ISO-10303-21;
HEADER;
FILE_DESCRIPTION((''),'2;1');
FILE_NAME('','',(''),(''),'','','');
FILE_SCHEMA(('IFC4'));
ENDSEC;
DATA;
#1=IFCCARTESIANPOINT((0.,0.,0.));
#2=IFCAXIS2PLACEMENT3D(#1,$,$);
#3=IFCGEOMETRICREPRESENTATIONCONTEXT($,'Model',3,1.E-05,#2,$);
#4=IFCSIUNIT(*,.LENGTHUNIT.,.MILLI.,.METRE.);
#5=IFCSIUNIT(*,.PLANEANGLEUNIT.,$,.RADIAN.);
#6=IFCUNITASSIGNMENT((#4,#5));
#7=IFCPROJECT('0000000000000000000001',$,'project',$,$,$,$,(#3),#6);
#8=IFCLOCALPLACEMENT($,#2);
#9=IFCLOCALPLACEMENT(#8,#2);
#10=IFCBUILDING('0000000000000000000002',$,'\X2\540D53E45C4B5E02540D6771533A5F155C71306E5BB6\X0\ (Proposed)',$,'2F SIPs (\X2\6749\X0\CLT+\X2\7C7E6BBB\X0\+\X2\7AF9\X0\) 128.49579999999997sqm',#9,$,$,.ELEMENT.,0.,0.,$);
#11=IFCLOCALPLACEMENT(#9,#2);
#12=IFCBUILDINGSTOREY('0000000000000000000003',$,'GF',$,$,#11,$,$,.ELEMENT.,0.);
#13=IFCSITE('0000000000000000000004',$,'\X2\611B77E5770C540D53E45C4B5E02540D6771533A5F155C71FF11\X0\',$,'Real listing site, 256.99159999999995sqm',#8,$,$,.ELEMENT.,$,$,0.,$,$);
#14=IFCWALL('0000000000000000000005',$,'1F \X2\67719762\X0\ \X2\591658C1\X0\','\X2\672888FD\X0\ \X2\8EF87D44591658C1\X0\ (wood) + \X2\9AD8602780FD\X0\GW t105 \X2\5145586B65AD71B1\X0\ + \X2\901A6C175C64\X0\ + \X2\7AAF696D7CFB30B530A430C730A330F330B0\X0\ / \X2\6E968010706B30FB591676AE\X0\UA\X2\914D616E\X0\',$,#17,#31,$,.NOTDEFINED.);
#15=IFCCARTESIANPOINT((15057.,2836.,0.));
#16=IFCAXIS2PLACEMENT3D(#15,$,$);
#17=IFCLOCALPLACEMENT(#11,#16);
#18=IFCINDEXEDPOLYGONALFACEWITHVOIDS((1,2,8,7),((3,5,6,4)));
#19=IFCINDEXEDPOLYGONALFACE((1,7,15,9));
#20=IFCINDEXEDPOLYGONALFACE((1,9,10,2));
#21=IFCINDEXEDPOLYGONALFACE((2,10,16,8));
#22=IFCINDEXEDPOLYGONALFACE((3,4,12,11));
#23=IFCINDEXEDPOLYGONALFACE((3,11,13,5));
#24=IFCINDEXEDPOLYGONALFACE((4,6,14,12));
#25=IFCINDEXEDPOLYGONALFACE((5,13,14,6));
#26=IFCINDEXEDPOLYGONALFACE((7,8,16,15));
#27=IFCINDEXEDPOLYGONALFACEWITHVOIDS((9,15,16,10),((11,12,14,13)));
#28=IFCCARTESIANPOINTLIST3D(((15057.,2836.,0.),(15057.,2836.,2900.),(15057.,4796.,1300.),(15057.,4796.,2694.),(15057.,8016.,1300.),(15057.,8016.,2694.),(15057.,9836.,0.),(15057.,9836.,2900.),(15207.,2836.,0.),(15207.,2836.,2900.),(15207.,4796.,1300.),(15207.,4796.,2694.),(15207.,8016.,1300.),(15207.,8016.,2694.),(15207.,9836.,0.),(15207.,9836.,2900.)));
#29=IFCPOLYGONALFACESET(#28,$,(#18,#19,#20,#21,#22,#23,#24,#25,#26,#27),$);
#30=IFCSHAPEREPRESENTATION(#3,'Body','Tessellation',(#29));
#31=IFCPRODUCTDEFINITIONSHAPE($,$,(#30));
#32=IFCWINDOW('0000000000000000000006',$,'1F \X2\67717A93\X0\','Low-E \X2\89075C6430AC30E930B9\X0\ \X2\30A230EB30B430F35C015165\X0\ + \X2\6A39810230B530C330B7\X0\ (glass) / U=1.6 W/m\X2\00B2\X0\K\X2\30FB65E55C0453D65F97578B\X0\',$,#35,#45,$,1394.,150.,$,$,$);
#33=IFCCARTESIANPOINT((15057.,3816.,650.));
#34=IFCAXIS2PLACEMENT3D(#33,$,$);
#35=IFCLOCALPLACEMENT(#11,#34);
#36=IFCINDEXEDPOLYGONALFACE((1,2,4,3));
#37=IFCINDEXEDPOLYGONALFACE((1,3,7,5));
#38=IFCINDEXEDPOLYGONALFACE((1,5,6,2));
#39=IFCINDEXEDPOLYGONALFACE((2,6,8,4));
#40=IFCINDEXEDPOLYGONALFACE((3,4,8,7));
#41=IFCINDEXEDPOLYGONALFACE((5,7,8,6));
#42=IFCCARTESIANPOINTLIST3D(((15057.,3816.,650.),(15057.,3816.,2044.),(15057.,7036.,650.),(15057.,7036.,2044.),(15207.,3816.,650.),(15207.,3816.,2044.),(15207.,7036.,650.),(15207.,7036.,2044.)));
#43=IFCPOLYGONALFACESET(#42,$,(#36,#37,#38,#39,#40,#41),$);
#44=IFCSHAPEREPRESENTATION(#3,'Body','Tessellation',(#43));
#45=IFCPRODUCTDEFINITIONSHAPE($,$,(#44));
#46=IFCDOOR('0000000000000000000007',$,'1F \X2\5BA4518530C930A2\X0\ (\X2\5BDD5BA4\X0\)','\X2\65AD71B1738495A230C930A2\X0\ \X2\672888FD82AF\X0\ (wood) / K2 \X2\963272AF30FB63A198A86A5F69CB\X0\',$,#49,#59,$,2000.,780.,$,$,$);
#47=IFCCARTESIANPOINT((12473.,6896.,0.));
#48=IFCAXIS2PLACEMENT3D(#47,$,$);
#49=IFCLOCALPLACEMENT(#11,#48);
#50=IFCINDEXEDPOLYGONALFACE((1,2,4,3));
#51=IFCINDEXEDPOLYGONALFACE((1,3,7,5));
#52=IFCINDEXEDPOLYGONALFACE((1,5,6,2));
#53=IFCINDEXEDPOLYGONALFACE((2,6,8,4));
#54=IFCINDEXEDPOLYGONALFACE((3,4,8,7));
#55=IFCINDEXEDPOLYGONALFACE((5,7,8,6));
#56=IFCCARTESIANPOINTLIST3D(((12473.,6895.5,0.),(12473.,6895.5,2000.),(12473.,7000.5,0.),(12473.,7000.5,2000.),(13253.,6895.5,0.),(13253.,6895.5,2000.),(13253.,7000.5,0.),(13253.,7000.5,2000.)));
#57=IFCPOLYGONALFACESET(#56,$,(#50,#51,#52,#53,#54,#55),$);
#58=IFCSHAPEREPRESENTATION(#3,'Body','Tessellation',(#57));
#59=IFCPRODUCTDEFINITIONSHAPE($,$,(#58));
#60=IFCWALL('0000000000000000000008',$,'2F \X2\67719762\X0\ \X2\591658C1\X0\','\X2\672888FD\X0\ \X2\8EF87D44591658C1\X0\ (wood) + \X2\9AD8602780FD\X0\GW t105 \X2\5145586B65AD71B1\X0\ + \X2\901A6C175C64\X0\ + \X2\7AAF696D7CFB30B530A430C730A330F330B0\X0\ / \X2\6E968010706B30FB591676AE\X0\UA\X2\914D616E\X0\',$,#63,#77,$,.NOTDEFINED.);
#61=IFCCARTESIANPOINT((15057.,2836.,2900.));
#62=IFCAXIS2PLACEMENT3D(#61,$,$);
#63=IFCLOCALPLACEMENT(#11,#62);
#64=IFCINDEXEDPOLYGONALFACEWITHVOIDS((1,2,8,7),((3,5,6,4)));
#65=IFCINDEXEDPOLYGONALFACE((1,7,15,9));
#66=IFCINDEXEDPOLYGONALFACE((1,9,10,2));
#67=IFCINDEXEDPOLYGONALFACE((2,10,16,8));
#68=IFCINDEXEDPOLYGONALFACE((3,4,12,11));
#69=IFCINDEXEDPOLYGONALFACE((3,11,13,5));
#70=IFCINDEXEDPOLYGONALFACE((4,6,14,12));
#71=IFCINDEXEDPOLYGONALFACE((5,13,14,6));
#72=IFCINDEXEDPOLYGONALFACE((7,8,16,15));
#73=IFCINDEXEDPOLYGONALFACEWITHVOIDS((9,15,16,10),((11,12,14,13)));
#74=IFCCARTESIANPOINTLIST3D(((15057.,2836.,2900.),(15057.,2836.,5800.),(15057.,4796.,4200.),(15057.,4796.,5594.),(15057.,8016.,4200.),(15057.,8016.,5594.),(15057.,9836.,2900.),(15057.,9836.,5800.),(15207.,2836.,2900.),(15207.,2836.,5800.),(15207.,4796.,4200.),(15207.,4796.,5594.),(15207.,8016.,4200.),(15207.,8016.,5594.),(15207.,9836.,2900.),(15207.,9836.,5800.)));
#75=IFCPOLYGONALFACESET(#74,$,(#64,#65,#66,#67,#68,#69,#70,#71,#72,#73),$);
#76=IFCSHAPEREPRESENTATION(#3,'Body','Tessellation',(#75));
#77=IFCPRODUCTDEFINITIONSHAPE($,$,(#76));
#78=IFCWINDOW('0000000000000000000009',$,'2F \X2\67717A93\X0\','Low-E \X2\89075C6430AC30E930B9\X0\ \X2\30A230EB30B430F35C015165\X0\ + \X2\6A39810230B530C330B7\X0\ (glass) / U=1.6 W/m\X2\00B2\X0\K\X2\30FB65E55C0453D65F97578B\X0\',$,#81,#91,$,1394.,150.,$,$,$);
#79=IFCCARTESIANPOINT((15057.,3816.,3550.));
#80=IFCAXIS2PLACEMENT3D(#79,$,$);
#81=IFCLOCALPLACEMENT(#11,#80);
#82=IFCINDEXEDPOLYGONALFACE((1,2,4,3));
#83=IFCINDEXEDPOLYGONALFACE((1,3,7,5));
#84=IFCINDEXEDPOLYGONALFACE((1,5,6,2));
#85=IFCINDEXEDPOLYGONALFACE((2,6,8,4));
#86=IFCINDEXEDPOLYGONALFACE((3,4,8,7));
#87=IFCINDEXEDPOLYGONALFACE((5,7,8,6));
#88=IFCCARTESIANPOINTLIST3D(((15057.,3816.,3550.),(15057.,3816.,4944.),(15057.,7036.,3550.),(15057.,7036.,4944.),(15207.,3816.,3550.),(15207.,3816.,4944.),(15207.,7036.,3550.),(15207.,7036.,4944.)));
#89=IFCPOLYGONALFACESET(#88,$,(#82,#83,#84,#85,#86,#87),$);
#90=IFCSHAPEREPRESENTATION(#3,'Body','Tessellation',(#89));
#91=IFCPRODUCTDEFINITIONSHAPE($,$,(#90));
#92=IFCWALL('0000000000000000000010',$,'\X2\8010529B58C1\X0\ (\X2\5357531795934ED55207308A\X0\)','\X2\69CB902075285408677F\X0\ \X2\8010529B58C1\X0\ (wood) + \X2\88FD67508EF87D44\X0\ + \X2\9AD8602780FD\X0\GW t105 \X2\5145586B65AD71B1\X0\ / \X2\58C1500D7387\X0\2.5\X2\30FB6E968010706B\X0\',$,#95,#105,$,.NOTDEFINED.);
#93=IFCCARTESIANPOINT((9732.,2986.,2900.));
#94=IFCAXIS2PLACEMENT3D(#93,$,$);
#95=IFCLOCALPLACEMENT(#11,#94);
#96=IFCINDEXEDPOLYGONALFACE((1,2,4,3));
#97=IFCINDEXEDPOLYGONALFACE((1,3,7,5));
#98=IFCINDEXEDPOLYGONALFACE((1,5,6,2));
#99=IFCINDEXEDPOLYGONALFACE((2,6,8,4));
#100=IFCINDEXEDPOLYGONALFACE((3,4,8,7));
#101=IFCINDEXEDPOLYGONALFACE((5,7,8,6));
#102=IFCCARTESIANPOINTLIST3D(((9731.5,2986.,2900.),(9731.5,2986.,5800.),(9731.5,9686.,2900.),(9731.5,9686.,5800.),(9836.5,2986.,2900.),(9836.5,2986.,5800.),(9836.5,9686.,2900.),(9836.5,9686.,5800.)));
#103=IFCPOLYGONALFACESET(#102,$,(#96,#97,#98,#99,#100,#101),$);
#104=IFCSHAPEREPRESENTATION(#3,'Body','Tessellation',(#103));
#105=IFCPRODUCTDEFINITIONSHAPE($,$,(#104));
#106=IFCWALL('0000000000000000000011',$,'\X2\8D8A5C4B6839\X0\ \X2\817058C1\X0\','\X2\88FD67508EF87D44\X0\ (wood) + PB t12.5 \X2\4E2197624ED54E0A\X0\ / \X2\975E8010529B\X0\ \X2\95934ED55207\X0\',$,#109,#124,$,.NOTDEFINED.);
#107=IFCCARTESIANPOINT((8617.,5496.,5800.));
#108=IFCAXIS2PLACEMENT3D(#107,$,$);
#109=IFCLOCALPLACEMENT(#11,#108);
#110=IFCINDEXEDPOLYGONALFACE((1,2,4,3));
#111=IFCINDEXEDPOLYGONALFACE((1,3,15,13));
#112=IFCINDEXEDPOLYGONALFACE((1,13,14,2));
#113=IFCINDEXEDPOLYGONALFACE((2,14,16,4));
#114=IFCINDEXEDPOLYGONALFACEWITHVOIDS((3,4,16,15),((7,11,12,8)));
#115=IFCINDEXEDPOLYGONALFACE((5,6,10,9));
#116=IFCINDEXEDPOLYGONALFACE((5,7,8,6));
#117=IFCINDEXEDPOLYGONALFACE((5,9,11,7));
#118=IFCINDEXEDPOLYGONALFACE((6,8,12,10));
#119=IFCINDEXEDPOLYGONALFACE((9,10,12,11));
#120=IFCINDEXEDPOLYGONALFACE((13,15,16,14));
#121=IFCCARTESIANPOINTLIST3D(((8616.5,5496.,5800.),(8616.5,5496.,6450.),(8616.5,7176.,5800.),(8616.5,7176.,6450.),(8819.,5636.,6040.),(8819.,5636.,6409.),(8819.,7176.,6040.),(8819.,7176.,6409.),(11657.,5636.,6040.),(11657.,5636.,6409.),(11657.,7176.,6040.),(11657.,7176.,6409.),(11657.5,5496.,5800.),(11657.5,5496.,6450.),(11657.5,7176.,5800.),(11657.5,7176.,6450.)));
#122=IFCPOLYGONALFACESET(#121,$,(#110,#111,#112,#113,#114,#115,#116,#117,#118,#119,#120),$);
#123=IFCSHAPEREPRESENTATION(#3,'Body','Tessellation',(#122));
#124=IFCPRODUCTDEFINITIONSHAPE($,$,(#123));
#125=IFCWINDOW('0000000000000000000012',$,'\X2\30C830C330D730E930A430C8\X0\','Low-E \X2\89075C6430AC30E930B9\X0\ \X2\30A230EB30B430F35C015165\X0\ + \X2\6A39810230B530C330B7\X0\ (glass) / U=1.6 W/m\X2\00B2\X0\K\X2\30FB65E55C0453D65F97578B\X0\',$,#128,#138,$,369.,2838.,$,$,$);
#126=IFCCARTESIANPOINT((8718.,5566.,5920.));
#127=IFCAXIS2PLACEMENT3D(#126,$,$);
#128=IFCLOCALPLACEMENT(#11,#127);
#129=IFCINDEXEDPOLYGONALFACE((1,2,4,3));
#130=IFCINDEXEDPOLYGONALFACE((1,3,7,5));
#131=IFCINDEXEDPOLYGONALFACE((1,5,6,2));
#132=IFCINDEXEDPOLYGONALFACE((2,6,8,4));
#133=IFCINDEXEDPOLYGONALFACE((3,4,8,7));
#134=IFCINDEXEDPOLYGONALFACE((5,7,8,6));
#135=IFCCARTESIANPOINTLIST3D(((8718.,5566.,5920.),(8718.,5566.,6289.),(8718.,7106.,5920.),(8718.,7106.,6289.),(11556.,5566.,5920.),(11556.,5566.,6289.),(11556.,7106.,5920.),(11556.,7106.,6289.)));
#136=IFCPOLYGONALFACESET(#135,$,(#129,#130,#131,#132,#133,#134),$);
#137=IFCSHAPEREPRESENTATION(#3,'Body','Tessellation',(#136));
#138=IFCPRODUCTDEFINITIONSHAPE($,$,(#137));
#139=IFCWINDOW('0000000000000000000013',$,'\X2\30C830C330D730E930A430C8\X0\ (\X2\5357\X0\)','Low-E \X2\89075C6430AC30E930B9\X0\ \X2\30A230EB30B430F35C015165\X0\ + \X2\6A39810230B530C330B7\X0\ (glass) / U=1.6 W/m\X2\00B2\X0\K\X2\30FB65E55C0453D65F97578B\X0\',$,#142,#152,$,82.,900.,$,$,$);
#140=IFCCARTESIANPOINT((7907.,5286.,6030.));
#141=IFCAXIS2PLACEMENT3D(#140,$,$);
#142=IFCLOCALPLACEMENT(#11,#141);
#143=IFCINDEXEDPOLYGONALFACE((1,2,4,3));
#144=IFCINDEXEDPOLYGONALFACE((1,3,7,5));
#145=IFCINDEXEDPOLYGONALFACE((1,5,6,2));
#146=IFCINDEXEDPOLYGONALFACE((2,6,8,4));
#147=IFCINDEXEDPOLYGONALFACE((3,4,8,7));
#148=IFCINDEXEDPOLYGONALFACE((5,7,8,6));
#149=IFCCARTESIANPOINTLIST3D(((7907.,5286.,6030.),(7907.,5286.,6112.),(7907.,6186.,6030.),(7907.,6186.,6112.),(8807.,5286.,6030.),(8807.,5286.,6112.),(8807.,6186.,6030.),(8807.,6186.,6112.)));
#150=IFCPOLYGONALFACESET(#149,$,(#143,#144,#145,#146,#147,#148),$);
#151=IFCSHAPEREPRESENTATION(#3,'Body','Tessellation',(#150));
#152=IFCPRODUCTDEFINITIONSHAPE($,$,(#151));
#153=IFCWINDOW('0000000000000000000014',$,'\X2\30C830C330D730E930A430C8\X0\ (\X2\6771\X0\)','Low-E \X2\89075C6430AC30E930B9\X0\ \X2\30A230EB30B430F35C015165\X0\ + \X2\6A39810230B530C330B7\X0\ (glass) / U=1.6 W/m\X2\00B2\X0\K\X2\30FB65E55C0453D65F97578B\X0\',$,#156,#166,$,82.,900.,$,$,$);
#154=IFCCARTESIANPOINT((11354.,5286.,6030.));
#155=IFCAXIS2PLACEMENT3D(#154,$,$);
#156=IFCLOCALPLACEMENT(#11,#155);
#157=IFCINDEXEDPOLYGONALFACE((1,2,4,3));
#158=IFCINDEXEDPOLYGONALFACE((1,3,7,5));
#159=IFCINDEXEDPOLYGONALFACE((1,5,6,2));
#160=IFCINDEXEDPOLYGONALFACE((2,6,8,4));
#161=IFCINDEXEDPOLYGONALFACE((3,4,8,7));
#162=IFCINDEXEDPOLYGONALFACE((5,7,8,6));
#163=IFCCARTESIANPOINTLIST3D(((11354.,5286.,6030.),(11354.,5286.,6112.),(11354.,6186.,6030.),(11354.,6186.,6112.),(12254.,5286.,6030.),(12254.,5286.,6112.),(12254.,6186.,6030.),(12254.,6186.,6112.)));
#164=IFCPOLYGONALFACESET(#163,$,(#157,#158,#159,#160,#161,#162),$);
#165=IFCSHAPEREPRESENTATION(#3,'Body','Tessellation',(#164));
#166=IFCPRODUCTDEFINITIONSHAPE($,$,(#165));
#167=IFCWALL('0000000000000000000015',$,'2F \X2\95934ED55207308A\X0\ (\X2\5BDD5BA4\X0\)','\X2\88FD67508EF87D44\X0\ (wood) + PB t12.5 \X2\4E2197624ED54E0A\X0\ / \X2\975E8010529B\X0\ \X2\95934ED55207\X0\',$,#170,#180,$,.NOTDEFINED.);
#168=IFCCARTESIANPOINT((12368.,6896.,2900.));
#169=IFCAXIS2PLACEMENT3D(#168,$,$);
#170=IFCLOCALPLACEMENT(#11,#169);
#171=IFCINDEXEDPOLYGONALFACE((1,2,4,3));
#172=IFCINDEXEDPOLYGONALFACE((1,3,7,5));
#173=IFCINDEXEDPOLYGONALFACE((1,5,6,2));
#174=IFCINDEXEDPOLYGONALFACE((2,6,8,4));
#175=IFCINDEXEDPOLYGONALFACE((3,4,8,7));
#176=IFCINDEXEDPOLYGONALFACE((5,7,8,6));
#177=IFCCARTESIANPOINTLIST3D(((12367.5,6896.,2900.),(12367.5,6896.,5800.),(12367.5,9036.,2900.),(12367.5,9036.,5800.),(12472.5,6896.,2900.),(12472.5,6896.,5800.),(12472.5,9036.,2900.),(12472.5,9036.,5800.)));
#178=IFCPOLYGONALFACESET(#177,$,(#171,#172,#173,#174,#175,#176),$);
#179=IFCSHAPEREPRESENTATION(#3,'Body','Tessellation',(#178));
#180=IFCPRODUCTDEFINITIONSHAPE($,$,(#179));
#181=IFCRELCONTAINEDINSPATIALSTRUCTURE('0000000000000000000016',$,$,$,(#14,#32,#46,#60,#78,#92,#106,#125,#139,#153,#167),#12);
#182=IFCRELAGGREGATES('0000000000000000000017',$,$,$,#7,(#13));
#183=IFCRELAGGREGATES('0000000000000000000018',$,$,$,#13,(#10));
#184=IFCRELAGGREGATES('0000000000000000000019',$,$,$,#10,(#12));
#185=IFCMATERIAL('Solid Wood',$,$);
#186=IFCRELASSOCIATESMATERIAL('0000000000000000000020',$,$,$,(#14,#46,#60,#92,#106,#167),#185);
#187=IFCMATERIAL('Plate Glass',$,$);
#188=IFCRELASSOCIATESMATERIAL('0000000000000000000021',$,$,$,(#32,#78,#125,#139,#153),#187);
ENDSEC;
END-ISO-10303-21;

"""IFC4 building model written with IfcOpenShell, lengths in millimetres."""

from ifc_helpers import new_model, si_unit, frame, frame_2d, origin, place, context, project, spatial, rectangle, extrude, material, element, fill, save


model = new_model("IFC4")

# Units and contexts
model_context = context("Model", 3, precision=1e-05, world=origin())
ifc_project = project(units=[si_unit("LENGTHUNIT", "METRE", prefix="MILLI"), si_unit("PLANEANGLEUNIT", "RADIAN")], contexts=[model_context])

# Site, building, storey
site_placement = place(None, origin())
site = spatial("IfcSite", under=ifc_project, at=site_placement, Name="愛知県名古屋市名東区引山１", ObjectType="Real listing site, 256.99159999999995sqm", CompositionType="ELEMENT", RefElevation=0.0)
building_placement = place(site_placement, origin())
building = spatial("IfcBuilding", under=site, at=building_placement, Name="名古屋市名東区引山の家 (Proposed)", ObjectType="2F SIPs (杉CLT+籾殻+竹) 128.49579999999997sqm", CompositionType="ELEMENT", ElevationOfRefHeight=0.0, ElevationOfTerrain=0.0)
storey_placement = place(building_placement, origin())
storey = spatial("IfcBuildingStorey", under=building, at=storey_placement, Name="GF", CompositionType="ELEMENT", Elevation=0.0)

# Wall, opening, window
ifc_material_1 = material(Name="Solid Wood")
wall_1_placement = place(storey_placement, frame((15057.0, 2836.0, 0.0)))
wall_1 = element("IfcWall", 1, at=wall_1_placement, inside=storey, material=ifc_material_1, Name="1F 東面 外壁", Description="木製 軸組外壁 (wood) + 高性能GW t105 充填断熱 + 通気層 + 窯業系サイディング / 準耐火・外皮UA配慮", PredefinedType="NOTDEFINED", context=model_context, shape_type="SweptSolid", body=[
    extrude(rectangle(XDim=150.0, YDim=7000.0, at=frame_2d((75.0, 3500.0))), frame((15057.0, 2836.0, 0.0)), (0.0, 0.0, 1.0), 2900.0),
])
opening_1_placement = place(storey_placement, frame((15057.0, 3816.0, 650.0)))
opening_1 = element("IfcOpeningElement", 2, at=opening_1_placement, cuts=wall_1, PredefinedType="NOTDEFINED", context=model_context, shape_type="SweptSolid", body=[
    extrude(rectangle(XDim=150.0, YDim=3220.0, at=frame_2d((75.0, 1610.0))), frame((15057.0, 3816.0, 650.0)), (0.0, 0.0, 1.0), 1394.0),
])
ifc_material_2 = material(Name="Plate Glass")
window_1_placement = place(storey_placement, frame((15057.0, 3816.0, 650.0)))
window_1 = element("IfcWindow", 3, at=window_1_placement, inside=storey, material=ifc_material_2, Name="1F 東窓", Description="Low-E 複層ガラス アルゴン封入 + 樹脂サッシ (glass) / U=1.6 W/m²K・日射取得型", OverallHeight=1394.0, OverallWidth=150.0, context=model_context, shape_type="SweptSolid", body=[
    extrude(rectangle(XDim=150.0, YDim=3220.0, at=frame_2d((75.0, 1610.0))), frame((15057.0, 3816.0, 650.0)), (0.0, 0.0, 1.0), 1394.0),
])
fill(opening_1, window_1)

# Door
door_1_placement = place(storey_placement, frame((12473.0, 6896.0, 0.0)))
element("IfcDoor", 4, at=door_1_placement, inside=storey, material=ifc_material_1, Name="1F 室内ドア (寝室)", Description="断熱玄関ドア 木製芯 (wood) / K2 防犯・採風機構", OverallHeight=2000.0, OverallWidth=780.0, context=model_context, shape_type="SweptSolid", body=[
    extrude(rectangle(XDim=780.0, YDim=105.0, at=frame_2d((390.0, 52.0))), frame((12473.0, 6896.0, 0.0)), (0.0, 0.0, 1.0), 2000.0),
])

# Wall, opening, window
wall_2_placement = place(storey_placement, frame((15057.0, 2836.0, 2900.0)))
wall_2 = element("IfcWall", 5, at=wall_2_placement, inside=storey, material=ifc_material_1, Name="2F 東面 外壁", Description="木製 軸組外壁 (wood) + 高性能GW t105 充填断熱 + 通気層 + 窯業系サイディング / 準耐火・外皮UA配慮", PredefinedType="NOTDEFINED", context=model_context, shape_type="SweptSolid", body=[
    extrude(rectangle(XDim=150.0, YDim=7000.0, at=frame_2d((75.0, 3500.0))), frame((15057.0, 2836.0, 2900.0)), (0.0, 0.0, 1.0), 2900.0),
])
opening_2_placement = place(storey_placement, frame((15057.0, 3816.0, 3550.0)))
opening_2 = element("IfcOpeningElement", 6, at=opening_2_placement, cuts=wall_2, PredefinedType="NOTDEFINED", context=model_context, shape_type="SweptSolid", body=[
    extrude(rectangle(XDim=150.0, YDim=3220.0, at=frame_2d((75.0, 1610.0))), frame((15057.0, 3816.0, 3550.0)), (0.0, 0.0, 1.0), 1394.0),
])
window_2_placement = place(storey_placement, frame((15057.0, 3816.0, 3550.0)))
window_2 = element("IfcWindow", 7, at=window_2_placement, inside=storey, material=ifc_material_2, Name="2F 東窓", Description="Low-E 複層ガラス アルゴン封入 + 樹脂サッシ (glass) / U=1.6 W/m²K・日射取得型", OverallHeight=1394.0, OverallWidth=150.0, context=model_context, shape_type="SweptSolid", body=[
    extrude(rectangle(XDim=150.0, YDim=3220.0, at=frame_2d((75.0, 1610.0))), frame((15057.0, 3816.0, 3550.0)), (0.0, 0.0, 1.0), 1394.0),
])
fill(opening_2, window_2)

# Wall
wall_3_placement = place(storey_placement, frame((9732.0, 2986.0, 2900.0)))
element("IfcWall", 8, at=wall_3_placement, inside=storey, material=ifc_material_1, Name="耐力壁 (南北間仕切り)", Description="構造用合板 耐力壁 (wood) + 製材軸組 + 高性能GW t105 充填断熱 / 壁倍率2.5・準耐火", PredefinedType="NOTDEFINED", context=model_context, shape_type="SweptSolid", body=[
    extrude(rectangle(XDim=105.0, YDim=6700.0, at=frame_2d((52.0, 3350.0))), frame((9732.0, 2986.0, 2900.0)), (0.0, 0.0, 1.0), 2900.0),
])

# Wall, openings, windows
wall_4_placement = place(storey_placement, frame((8617.0, 5496.0, 5800.0)))
wall_4 = element("IfcWall", 9, at=wall_4_placement, inside=storey, material=ifc_material_1, Name="越屋根 腰壁", Description="製材軸組 (wood) + PB t12.5 両面仕上 / 非耐力 間仕切", PredefinedType="NOTDEFINED", context=model_context, shape_type="SweptSolid", body=[
    extrude(rectangle(XDim=3041.0, YDim=1680.0, at=frame_2d((1520.0, 840.0))), frame((8617.0, 5496.0, 5800.0)), (0.0, 0.0, 1.0), 650.0),
])
opening_3_placement = place(storey_placement, frame((8718.0, 5566.0, 5920.0)))
opening_3 = element("IfcOpeningElement", 10, at=opening_3_placement, cuts=wall_4, PredefinedType="NOTDEFINED", context=model_context, shape_type="SweptSolid", body=[
    extrude(rectangle(XDim=2838.0, YDim=1540.0, at=frame_2d((1419.0, 770.0))), frame((8718.0, 5566.0, 5920.0)), (0.0, 0.0, 1.0), 369.0),
])
opening_4_placement = place(storey_placement, frame((7907.0, 5286.0, 6030.0)))
opening_4 = element("IfcOpeningElement", 11, at=opening_4_placement, cuts=wall_4, PredefinedType="NOTDEFINED", context=model_context, shape_type="SweptSolid", body=[
    extrude(rectangle(XDim=900.0, YDim=900.0, at=frame_2d((450.0, 450.0))), frame((7907.0, 5286.0, 6030.0)), (0.0, 0.0, 1.0), 82.0),
])
opening_5_placement = place(storey_placement, frame((11354.0, 5286.0, 6030.0)))
opening_5 = element("IfcOpeningElement", 12, at=opening_5_placement, cuts=wall_4, PredefinedType="NOTDEFINED", context=model_context, shape_type="SweptSolid", body=[
    extrude(rectangle(XDim=900.0, YDim=900.0, at=frame_2d((450.0, 450.0))), frame((11354.0, 5286.0, 6030.0)), (0.0, 0.0, 1.0), 82.0),
])
window_3_placement = place(storey_placement, frame((8718.0, 5566.0, 5920.0)))
window_3 = element("IfcWindow", 13, at=window_3_placement, inside=storey, material=ifc_material_2, Name="トップライト", Description="Low-E 複層ガラス アルゴン封入 + 樹脂サッシ (glass) / U=1.6 W/m²K・日射取得型", OverallHeight=369.0, OverallWidth=2838.0, context=model_context, shape_type="SweptSolid", body=[
    extrude(rectangle(XDim=2838.0, YDim=1540.0, at=frame_2d((1419.0, 770.0))), frame((8718.0, 5566.0, 5920.0)), (0.0, 0.0, 1.0), 369.0),
])
fill(opening_3, window_3)
window_4_placement = place(storey_placement, frame((7907.0, 5286.0, 6030.0)))
window_4 = element("IfcWindow", 14, at=window_4_placement, inside=storey, material=ifc_material_2, Name="トップライト (南)", Description="Low-E 複層ガラス アルゴン封入 + 樹脂サッシ (glass) / U=1.6 W/m²K・日射取得型", OverallHeight=82.0, OverallWidth=900.0, context=model_context, shape_type="SweptSolid", body=[
    extrude(rectangle(XDim=900.0, YDim=900.0, at=frame_2d((450.0, 450.0))), frame((7907.0, 5286.0, 6030.0)), (0.0, 0.0, 1.0), 82.0),
])
fill(opening_4, window_4)
window_5_placement = place(storey_placement, frame((11354.0, 5286.0, 6030.0)))
window_5 = element("IfcWindow", 15, at=window_5_placement, inside=storey, material=ifc_material_2, Name="トップライト (東)", Description="Low-E 複層ガラス アルゴン封入 + 樹脂サッシ (glass) / U=1.6 W/m²K・日射取得型", OverallHeight=82.0, OverallWidth=900.0, context=model_context, shape_type="SweptSolid", body=[
    extrude(rectangle(XDim=900.0, YDim=900.0, at=frame_2d((450.0, 450.0))), frame((11354.0, 5286.0, 6030.0)), (0.0, 0.0, 1.0), 82.0),
])
fill(opening_5, window_5)

# Wall
wall_5_placement = place(storey_placement, frame((12368.0, 6896.0, 2900.0)))
element("IfcWall", 16, at=wall_5_placement, inside=storey, material=ifc_material_1, Name="2F 間仕切り (寝室)", Description="製材軸組 (wood) + PB t12.5 両面仕上 / 非耐力 間仕切", PredefinedType="NOTDEFINED", context=model_context, shape_type="SweptSolid", body=[
    extrude(rectangle(XDim=105.0, YDim=2140.0, at=frame_2d((52.0, 1070.0))), frame((12368.0, 6896.0, 2900.0)), (0.0, 0.0, 1.0), 2900.0),
])

save(model, "model.ifc")
